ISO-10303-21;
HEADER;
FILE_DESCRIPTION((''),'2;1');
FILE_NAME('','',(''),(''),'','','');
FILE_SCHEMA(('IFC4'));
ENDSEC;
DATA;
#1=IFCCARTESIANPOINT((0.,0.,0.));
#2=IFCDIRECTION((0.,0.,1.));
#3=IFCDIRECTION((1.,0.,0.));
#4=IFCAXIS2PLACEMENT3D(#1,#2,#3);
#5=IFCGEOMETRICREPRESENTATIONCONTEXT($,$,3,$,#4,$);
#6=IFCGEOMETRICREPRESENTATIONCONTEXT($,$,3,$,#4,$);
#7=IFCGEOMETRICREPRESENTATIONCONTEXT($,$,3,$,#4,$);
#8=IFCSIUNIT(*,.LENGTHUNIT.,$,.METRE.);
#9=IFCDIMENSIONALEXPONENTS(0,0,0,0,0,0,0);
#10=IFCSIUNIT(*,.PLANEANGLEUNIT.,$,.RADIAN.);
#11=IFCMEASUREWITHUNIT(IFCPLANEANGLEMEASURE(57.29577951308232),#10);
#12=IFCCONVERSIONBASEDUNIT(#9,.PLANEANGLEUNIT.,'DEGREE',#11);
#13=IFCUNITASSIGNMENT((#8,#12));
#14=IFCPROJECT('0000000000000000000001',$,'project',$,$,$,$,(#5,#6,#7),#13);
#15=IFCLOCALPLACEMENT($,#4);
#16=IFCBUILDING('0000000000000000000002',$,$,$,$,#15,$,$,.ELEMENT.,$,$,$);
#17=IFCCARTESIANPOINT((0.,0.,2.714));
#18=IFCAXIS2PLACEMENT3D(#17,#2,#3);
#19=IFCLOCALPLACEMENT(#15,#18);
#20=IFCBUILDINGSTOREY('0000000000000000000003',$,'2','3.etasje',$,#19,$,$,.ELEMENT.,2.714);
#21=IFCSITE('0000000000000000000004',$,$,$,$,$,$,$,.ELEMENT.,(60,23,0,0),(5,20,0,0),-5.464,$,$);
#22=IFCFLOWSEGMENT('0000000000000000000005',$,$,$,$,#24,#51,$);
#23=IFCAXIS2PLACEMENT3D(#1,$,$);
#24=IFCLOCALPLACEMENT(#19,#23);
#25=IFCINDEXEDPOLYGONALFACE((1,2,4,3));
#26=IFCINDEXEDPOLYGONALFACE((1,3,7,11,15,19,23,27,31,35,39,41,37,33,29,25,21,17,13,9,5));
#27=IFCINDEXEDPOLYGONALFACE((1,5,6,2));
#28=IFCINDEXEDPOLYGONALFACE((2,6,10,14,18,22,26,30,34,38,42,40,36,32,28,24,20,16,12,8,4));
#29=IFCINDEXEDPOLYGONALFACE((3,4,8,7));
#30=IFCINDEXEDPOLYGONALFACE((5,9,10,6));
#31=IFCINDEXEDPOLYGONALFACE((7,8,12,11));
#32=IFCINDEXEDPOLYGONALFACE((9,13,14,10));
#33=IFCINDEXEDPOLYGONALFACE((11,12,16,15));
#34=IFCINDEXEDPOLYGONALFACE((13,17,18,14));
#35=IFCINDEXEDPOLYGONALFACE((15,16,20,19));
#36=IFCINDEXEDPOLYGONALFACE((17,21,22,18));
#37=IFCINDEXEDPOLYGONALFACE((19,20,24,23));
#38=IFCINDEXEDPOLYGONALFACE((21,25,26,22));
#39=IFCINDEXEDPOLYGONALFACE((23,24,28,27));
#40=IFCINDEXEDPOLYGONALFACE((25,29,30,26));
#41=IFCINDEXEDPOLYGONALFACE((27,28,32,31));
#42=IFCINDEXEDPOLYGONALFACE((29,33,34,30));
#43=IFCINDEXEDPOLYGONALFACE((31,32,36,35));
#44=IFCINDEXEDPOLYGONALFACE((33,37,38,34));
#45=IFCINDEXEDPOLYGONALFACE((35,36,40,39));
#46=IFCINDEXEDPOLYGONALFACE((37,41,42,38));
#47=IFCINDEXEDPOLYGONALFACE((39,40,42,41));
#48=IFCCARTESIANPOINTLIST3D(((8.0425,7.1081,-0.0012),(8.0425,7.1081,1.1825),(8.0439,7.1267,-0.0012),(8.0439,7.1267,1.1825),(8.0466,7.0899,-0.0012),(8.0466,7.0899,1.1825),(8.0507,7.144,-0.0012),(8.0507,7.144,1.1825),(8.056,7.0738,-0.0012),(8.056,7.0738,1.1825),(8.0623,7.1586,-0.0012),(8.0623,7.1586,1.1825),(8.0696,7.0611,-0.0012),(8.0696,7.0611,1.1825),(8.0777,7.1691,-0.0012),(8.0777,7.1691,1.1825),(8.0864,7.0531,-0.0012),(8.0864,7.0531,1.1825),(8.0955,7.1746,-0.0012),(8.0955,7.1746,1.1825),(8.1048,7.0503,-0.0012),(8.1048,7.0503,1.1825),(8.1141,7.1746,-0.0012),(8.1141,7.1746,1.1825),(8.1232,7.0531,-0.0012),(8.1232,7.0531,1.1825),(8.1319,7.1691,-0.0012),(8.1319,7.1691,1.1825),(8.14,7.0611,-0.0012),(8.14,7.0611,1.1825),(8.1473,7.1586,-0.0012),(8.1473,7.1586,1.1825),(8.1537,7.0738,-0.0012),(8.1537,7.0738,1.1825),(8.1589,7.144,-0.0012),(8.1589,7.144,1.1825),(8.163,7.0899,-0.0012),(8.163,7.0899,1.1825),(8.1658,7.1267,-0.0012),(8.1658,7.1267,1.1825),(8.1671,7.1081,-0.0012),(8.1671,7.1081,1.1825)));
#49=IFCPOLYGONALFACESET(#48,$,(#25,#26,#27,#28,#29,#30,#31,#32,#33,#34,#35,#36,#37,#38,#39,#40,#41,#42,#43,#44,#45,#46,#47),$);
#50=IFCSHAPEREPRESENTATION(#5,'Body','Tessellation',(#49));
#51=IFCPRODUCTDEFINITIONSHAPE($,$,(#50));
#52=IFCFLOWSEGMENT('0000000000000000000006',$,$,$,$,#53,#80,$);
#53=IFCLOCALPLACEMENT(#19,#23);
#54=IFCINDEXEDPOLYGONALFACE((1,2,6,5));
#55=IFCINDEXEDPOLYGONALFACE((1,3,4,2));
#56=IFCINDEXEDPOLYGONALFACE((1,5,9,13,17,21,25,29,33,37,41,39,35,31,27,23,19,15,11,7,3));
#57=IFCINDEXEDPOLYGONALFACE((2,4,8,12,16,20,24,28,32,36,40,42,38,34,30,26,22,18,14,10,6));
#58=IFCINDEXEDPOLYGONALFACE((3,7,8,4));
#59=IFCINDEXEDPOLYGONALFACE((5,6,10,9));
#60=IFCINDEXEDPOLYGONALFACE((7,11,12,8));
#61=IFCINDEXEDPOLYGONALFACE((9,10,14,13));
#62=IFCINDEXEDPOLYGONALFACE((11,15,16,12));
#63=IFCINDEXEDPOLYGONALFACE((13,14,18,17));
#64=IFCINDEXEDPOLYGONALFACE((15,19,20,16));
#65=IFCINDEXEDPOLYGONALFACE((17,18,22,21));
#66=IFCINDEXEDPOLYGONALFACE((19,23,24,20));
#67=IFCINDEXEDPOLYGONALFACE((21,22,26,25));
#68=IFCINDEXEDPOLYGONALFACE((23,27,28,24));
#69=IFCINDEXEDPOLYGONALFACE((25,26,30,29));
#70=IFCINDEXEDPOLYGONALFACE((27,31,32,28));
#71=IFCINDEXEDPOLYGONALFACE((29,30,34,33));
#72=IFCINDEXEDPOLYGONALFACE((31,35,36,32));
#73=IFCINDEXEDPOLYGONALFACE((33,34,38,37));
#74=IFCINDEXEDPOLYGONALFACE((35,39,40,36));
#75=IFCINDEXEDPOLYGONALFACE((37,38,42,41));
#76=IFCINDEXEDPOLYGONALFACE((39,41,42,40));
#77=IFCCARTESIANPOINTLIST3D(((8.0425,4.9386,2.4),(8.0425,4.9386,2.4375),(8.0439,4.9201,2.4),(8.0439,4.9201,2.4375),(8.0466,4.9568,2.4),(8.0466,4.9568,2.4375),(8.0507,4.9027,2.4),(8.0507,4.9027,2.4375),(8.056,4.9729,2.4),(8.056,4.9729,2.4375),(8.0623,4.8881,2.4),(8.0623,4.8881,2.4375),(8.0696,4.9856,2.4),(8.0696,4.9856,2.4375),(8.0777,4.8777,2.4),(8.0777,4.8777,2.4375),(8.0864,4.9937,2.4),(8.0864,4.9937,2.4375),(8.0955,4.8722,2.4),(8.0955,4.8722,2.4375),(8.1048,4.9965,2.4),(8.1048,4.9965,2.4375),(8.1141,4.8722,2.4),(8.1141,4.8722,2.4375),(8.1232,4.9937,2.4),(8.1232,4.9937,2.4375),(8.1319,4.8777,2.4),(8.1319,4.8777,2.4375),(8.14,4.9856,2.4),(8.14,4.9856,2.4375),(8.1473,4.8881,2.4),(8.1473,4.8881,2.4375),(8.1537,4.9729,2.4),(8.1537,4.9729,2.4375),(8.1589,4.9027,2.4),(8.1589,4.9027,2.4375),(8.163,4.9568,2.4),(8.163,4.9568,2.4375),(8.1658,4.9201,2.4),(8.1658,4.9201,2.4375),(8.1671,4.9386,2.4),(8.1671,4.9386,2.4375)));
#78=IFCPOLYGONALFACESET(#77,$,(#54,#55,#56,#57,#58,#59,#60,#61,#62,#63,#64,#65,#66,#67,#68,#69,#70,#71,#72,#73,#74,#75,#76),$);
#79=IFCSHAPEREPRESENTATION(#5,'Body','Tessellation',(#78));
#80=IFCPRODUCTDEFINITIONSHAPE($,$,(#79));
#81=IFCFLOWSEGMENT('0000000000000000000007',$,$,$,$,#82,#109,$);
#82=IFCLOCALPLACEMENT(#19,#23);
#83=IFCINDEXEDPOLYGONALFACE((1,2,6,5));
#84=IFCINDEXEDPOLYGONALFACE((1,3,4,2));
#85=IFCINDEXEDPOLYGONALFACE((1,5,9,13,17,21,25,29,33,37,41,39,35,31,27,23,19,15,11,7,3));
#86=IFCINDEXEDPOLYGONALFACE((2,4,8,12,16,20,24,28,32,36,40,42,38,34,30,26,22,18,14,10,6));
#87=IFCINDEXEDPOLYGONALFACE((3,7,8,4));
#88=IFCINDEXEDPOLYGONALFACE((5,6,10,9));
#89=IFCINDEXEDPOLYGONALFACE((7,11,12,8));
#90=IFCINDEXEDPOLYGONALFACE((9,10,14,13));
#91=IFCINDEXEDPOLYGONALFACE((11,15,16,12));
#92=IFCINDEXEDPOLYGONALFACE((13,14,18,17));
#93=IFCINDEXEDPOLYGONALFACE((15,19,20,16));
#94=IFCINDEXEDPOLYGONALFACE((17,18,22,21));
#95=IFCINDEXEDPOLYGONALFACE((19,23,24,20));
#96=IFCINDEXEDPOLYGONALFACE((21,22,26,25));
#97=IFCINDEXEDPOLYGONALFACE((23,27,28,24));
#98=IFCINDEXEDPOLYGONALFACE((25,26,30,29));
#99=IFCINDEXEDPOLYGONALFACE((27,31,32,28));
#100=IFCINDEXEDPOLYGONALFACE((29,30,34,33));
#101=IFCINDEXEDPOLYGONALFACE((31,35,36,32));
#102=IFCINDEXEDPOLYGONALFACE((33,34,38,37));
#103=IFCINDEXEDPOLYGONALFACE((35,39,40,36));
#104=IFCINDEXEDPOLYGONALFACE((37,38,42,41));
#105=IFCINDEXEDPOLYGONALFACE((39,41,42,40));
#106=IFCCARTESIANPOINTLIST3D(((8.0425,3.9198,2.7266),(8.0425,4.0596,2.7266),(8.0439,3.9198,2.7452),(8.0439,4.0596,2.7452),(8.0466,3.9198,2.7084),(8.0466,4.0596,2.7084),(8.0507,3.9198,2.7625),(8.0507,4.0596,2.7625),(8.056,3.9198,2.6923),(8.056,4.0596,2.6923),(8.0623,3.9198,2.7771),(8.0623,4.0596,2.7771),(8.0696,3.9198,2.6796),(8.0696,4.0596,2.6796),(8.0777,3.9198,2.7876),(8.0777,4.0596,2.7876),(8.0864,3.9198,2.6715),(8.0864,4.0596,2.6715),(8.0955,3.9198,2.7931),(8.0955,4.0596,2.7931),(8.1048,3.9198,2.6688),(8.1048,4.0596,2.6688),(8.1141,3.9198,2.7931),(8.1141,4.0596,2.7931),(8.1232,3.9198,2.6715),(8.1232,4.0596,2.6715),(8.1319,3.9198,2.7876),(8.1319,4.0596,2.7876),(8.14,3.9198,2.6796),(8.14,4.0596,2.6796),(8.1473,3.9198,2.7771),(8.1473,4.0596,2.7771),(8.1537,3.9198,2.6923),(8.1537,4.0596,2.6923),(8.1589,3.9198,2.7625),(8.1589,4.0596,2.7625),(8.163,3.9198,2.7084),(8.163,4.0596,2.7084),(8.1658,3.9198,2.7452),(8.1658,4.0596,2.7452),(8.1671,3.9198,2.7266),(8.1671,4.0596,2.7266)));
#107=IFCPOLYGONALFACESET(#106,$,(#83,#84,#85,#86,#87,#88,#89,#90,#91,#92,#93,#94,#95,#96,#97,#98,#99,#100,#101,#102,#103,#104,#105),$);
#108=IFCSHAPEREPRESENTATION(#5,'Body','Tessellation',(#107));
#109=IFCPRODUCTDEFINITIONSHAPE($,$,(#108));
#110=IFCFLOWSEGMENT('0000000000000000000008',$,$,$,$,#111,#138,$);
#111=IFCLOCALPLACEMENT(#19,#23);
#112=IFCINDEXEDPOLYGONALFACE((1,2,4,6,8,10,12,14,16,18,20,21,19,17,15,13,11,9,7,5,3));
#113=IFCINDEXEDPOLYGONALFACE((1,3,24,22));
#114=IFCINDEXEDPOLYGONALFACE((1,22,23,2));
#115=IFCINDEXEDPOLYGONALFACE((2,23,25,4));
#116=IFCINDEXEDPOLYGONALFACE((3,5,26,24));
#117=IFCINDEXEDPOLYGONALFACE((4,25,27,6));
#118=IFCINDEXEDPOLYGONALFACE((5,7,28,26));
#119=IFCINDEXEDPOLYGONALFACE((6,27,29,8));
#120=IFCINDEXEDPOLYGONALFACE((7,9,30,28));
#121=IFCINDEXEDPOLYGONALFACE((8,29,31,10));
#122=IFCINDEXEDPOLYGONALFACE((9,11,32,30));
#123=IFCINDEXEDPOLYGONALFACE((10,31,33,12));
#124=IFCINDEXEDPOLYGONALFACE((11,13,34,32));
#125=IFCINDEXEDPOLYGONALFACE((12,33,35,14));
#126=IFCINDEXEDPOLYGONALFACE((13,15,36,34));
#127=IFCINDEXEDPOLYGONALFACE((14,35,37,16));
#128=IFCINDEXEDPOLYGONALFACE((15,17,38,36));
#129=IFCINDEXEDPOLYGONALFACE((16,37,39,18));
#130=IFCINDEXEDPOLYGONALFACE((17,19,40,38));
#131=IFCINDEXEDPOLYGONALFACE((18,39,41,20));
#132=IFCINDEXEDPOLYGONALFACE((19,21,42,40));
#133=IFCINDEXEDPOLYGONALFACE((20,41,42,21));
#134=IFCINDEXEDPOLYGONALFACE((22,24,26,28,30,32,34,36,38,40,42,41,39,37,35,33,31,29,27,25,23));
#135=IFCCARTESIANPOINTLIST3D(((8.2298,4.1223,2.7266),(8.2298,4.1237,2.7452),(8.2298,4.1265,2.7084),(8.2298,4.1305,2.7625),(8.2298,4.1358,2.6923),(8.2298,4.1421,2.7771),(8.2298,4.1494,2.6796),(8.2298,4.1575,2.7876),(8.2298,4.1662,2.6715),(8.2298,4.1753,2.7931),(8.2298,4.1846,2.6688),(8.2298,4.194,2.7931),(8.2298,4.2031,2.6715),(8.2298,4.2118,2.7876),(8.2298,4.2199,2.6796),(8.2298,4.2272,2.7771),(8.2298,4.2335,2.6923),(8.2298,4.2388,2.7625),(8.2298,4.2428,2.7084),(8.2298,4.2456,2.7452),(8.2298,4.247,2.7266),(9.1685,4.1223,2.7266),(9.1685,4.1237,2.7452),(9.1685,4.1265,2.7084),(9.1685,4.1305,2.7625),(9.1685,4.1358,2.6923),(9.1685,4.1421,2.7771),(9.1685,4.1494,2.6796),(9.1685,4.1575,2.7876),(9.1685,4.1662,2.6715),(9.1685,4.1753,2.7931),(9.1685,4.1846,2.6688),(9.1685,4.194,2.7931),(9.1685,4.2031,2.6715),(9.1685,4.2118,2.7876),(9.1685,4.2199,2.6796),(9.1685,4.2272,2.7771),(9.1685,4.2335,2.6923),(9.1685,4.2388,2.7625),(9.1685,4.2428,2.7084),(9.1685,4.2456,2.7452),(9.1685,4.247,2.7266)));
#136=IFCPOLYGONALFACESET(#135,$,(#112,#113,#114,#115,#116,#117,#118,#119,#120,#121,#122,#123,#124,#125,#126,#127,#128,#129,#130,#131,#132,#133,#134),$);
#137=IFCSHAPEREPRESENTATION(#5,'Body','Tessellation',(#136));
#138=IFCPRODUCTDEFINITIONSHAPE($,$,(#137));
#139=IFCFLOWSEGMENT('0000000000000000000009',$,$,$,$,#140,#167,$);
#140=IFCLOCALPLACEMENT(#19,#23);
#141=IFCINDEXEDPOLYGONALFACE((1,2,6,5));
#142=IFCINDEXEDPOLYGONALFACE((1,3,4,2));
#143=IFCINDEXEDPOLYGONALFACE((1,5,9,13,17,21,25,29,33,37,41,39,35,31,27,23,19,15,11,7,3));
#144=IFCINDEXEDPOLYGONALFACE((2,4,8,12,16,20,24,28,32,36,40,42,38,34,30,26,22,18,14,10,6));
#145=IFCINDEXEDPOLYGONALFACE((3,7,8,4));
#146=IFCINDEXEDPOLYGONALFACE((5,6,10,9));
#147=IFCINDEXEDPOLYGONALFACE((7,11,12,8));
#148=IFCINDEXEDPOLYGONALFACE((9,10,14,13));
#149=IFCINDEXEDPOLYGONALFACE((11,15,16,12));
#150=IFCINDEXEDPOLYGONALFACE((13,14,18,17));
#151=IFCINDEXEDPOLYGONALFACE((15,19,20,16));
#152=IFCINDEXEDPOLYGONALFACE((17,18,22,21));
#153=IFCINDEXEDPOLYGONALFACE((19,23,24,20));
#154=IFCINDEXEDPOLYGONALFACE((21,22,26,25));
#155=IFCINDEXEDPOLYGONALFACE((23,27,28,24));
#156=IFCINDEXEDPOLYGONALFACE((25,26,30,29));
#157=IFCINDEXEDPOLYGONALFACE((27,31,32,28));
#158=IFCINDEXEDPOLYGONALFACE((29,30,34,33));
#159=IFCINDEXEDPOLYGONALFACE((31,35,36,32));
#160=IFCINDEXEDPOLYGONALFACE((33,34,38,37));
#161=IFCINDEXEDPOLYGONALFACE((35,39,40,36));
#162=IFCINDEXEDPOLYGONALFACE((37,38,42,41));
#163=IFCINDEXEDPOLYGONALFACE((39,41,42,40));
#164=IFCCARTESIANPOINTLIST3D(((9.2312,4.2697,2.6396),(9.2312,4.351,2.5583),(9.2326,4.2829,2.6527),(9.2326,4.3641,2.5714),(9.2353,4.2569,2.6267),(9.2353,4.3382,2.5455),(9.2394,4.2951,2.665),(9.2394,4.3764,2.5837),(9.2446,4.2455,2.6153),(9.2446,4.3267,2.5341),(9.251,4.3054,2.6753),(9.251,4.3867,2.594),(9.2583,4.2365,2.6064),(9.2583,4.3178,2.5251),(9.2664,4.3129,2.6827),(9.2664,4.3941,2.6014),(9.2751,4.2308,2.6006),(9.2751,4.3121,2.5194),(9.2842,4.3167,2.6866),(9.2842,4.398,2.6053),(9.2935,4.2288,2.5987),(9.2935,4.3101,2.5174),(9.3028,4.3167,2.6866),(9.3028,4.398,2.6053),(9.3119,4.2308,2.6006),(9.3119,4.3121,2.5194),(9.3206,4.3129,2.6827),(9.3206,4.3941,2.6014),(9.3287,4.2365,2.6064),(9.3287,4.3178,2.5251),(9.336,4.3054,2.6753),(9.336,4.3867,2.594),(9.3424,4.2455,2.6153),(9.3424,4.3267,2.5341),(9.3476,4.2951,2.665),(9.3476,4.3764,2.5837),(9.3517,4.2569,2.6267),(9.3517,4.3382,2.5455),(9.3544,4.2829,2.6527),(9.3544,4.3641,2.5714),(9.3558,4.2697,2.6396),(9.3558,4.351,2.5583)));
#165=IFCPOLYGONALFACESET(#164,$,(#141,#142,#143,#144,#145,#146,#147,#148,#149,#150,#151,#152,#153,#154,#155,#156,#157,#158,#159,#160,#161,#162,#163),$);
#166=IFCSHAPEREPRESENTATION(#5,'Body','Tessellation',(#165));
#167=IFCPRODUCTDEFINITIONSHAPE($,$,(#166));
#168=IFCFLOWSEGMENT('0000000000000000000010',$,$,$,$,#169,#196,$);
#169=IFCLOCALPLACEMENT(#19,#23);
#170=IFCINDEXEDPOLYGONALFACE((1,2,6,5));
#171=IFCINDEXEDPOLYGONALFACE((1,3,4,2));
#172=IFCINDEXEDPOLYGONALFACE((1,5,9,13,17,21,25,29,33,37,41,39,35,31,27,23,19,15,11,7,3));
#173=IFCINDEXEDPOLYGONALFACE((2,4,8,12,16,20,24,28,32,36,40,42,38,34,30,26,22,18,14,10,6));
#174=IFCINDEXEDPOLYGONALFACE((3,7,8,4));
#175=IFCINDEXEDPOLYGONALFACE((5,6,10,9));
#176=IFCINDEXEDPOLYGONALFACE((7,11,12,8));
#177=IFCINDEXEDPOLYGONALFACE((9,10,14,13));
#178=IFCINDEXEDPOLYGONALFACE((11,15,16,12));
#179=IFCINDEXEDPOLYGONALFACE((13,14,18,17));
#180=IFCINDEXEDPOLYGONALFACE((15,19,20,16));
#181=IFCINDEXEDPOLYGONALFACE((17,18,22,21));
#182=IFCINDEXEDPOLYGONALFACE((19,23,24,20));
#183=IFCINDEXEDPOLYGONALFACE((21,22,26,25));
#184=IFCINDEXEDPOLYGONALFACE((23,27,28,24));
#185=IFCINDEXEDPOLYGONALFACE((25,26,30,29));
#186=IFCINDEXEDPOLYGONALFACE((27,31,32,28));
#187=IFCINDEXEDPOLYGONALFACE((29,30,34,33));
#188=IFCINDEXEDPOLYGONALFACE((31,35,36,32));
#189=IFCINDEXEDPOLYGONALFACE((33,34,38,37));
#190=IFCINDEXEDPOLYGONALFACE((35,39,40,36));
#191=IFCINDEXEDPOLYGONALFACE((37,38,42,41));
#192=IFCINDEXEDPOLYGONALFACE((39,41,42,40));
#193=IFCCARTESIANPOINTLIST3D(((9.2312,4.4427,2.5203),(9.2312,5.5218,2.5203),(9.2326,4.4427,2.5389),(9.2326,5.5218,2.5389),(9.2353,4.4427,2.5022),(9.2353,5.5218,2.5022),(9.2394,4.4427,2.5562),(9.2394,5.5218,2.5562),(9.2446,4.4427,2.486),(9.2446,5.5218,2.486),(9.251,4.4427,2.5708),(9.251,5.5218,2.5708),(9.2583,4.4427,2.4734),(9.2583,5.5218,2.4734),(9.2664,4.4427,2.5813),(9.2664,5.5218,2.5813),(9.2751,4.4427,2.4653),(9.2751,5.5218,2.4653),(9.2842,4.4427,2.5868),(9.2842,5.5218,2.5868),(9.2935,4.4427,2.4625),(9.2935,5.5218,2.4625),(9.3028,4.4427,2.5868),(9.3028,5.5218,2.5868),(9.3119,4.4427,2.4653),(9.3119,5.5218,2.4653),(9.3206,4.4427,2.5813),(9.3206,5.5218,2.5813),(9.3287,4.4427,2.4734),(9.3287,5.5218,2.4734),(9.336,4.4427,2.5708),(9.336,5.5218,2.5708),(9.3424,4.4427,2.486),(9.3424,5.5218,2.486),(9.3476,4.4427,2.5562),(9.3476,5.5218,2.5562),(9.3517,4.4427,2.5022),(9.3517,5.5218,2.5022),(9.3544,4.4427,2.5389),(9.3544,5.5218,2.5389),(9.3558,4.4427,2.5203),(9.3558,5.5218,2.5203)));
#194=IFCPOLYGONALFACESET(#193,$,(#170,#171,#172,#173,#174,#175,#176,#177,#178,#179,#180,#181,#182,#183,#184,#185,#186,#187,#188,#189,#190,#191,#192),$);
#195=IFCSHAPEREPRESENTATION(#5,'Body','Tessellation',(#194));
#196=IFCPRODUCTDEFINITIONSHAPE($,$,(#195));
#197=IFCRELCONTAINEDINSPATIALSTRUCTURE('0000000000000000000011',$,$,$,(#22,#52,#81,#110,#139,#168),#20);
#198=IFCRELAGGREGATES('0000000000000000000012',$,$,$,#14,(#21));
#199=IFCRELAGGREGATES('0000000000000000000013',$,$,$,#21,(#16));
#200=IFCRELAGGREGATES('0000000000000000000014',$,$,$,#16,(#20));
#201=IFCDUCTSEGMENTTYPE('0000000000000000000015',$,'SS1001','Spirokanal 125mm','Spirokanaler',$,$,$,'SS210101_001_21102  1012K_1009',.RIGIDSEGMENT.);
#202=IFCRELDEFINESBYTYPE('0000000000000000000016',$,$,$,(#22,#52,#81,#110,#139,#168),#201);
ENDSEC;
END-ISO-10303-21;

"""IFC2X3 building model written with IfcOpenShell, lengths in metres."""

from ifc_helpers import new_model, entity, si_unit, converted_unit, frame, origin_with_axes, origin_2d_with_axis, place, context, project, spatial, circle, extrude, type_object, element, save


model = new_model("IFC2X3")

# Units and contexts
context_of_model_1 = context(None, 3, world=origin_with_axes())
context_of_model_2 = context(None, 3, world=origin_with_axes())
context_of_model_3 = context(None, 3, world=origin_with_axes())
ifc_project = project(units=[si_unit("LENGTHUNIT", "METRE"), converted_unit("PLANEANGLEUNIT", "DEGREE", entity("IfcPlaneAngleMeasure", 57.29577951308232), si_unit("PLANEANGLEUNIT", "RADIAN"), dimensions=[0, 0, 0, 0, 0, 0, 0])], contexts=[context_of_model_1, context_of_model_2, context_of_model_3])

# Site, building, storey
site = spatial("IfcSite", under=ifc_project, CompositionType="ELEMENT", RefLatitude=(60, 23, 0, 0), RefLongitude=(5, 20, 0, 0), RefElevation=-5.464)
building_placement = place(None, origin_with_axes())
building = spatial("IfcBuilding", under=site, at=building_placement, CompositionType="ELEMENT")
storey_placement = place(building_placement, frame((0.0, 0.0, 2.714), z_axis=(0.0, 0.0, 1.0), x_axis=(1.0, 0.0, 0.0)))
storey = spatial("IfcBuildingStorey", under=building, at=storey_placement, Name="2", Description="3.etasje", CompositionType="ELEMENT", Elevation=2.714)

# Flow segments
duct_segment_type_1 = type_object("IfcDuctSegmentType", Name="SS1001", Description="Spirokanal 125mm", ApplicableOccurrence="Spirokanaler", ElementType="SS210101_001_21102  1012K_1009", PredefinedType="RIGIDSEGMENT")
flow_segment_1_placement = place(storey_placement, frame((8.1048, 7.1128, 1.1825), z_axis=(0.0, 0.0, -1.0), x_axis=(0.0, -1.0, 0.0)))
element("IfcFlowSegment", 1, at=flow_segment_1_placement, inside=storey, type_object=duct_segment_type_1, context=context_of_model_1, shape_type="SweptSolid", body=[
    extrude(circle(Radius=0.0625, at=origin_2d_with_axis()), origin_with_axes(), (0.0, 0.0, 1.0), 1.1837),
])
flow_segment_2_placement = place(storey_placement, frame((8.1048, 4.934, 2.4375), z_axis=(0.0, 0.0, -1.0), x_axis=(0.0, 1.0, 0.0)))
element("IfcFlowSegment", 2, at=flow_segment_2_placement, inside=storey, type_object=duct_segment_type_1, context=context_of_model_1, shape_type="SweptSolid", body=[
    extrude(circle(Radius=0.0625, at=origin_2d_with_axis()), origin_with_axes(), (0.0, 0.0, 1.0), 0.0375),
])
flow_segment_3_placement = place(storey_placement, frame((8.1048, 3.9198, 2.7313), z_axis=(0.0, 1.0, 0.0), x_axis=(0.0, 0.0, -1.0)))
element("IfcFlowSegment", 3, at=flow_segment_3_placement, inside=storey, type_object=duct_segment_type_1, context=context_of_model_1, shape_type="SweptSolid", body=[
    extrude(circle(Radius=0.0625, at=origin_2d_with_axis()), origin_with_axes(), (0.0, 0.0, 1.0), 0.1399),
])
flow_segment_4_placement = place(storey_placement, frame((8.2298, 4.1846, 2.7313), z_axis=(1.0, 0.0, 0.0), x_axis=(0.0, 0.0, -1.0)))
element("IfcFlowSegment", 4, at=flow_segment_4_placement, inside=storey, type_object=duct_segment_type_1, context=context_of_model_1, shape_type="SweptSolid", body=[
    extrude(circle(Radius=0.0625, at=origin_2d_with_axis()), origin_with_axes(), (0.0, 0.0, 1.0), 0.9387),
])
flow_segment_5_placement = place(storey_placement, frame((9.2935, 4.273, 2.6429), z_axis=(0.0, 0.707107, -0.707107), x_axis=(0.0, -0.707107, -0.707107)))
element("IfcFlowSegment", 5, at=flow_segment_5_placement, inside=storey, type_object=duct_segment_type_1, context=context_of_model_1, shape_type="SweptSolid", body=[
    extrude(circle(Radius=0.0625, at=origin_2d_with_axis()), origin_with_axes(), (0.0, 0.0, 1.0), 0.1149),
])
flow_segment_6_placement = place(storey_placement, frame((9.2935, 4.4427, 2.525), z_axis=(0.0, 1.0, 0.0), x_axis=(0.0, 0.0, -1.0)))
element("IfcFlowSegment", 6, at=flow_segment_6_placement, inside=storey, type_object=duct_segment_type_1, context=context_of_model_1, shape_type="SweptSolid", body=[
    extrude(circle(Radius=0.0625, at=origin_2d_with_axis()), origin_with_axes(), (0.0, 0.0, 1.0), 1.0791),
])

save(model, "model.ifc")
